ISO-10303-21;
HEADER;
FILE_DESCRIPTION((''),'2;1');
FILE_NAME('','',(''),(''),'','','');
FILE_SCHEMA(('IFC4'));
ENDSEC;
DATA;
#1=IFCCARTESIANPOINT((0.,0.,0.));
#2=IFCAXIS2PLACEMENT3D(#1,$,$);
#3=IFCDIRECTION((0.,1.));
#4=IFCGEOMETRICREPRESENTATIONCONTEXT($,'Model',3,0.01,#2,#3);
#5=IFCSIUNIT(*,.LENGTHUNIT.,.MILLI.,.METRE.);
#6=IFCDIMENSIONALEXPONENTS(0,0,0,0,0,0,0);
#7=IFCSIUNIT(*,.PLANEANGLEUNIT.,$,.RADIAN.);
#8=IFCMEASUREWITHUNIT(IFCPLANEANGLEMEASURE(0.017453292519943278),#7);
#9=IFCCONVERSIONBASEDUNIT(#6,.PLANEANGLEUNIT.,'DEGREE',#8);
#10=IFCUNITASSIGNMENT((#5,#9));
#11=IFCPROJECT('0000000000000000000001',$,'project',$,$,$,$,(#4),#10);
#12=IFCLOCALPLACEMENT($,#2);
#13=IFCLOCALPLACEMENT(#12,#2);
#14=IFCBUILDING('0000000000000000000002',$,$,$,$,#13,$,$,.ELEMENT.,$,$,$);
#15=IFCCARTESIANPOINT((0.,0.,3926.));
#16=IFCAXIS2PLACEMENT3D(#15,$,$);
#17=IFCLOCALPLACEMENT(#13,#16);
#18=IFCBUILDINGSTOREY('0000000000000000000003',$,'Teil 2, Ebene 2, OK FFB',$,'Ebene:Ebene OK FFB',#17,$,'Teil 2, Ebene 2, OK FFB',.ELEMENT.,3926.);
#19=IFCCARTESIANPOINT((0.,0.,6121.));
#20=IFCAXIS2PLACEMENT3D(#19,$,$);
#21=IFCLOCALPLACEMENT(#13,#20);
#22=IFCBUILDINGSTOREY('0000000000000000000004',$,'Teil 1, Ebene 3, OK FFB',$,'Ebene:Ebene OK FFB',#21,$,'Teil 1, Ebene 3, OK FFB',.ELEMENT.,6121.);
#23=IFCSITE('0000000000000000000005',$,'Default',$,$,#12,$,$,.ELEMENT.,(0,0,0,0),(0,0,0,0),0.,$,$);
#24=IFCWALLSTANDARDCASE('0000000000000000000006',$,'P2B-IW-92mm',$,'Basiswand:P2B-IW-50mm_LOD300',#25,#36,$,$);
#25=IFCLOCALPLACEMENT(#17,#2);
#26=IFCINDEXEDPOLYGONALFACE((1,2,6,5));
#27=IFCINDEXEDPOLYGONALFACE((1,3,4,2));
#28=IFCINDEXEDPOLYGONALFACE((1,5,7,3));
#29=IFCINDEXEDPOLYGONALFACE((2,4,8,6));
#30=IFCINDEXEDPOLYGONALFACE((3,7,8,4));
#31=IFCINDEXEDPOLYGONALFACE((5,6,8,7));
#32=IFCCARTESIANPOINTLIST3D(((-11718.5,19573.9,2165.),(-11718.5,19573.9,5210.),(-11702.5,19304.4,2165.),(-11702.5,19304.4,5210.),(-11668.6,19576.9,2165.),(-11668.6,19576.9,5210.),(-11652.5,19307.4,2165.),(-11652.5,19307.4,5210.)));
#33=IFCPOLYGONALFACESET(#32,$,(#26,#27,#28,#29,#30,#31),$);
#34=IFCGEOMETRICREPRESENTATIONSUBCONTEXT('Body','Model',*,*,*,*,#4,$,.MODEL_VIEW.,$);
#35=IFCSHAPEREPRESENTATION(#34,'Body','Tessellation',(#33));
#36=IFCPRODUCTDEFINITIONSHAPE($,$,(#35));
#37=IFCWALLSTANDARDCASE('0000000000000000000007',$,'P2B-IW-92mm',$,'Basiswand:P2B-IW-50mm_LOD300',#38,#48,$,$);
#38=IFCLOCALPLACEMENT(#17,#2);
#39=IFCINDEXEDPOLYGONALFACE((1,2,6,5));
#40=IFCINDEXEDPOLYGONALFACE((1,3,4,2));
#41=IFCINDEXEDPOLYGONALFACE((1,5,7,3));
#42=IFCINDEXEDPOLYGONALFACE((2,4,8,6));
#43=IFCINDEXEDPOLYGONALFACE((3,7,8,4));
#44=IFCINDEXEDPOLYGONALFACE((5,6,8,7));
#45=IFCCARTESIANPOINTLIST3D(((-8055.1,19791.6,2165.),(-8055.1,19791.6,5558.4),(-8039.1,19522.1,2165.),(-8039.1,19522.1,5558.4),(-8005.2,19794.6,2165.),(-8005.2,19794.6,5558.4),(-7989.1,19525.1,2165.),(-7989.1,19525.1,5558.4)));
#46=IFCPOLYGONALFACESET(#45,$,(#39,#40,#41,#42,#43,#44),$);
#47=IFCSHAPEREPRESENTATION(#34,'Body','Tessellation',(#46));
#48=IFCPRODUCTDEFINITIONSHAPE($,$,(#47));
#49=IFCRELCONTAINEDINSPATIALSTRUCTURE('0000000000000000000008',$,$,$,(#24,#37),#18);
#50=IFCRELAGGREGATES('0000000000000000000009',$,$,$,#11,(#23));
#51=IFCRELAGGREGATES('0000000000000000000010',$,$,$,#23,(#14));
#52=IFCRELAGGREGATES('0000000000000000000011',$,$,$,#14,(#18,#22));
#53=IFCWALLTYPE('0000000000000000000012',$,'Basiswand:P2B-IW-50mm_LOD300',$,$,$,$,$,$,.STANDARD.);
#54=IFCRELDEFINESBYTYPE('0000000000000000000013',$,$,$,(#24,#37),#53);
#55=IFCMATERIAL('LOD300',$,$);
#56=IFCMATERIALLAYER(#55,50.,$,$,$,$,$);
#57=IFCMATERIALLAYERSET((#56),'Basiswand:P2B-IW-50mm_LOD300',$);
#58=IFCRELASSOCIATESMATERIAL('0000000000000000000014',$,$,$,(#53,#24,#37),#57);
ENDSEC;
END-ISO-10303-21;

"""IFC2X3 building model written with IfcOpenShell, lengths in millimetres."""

from ifc_helpers import new_model, entity, si_unit, converted_unit, direction, frame, frame_2d, origin, place, context, subcontext, project, spatial, rectangle, extrude, material, layer, layer_set, layer_usage, type_object, element, save


model = new_model("IFC2X3")

# Units and contexts
model_context = context("Model", 3, precision=0.01, world=origin(), true_north=direction((0.0, 1.0)))
body_context = subcontext(model_context, "Body", "Model", "MODEL_VIEW")
ifc_project = project(units=[si_unit("LENGTHUNIT", "METRE", prefix="MILLI"), converted_unit("PLANEANGLEUNIT", "DEGREE", entity("IfcPlaneAngleMeasure", 0.017453292519943278), si_unit("PLANEANGLEUNIT", "RADIAN"), dimensions=[0, 0, 0, 0, 0, 0, 0])], contexts=[model_context])

# Site, building, storey
site_placement = place(None, origin())
site = spatial("IfcSite", under=ifc_project, at=site_placement, Name="Default", CompositionType="ELEMENT", RefLatitude=(0, 0, 0, 0), RefLongitude=(0, 0, 0, 0), RefElevation=0.0)
building_placement = place(site_placement, origin())
building = spatial("IfcBuilding", under=site, at=building_placement, CompositionType="ELEMENT")
storey_1_placement = place(building_placement, frame((0.0, 0.0, 3926.0)))
storey_1 = spatial("IfcBuildingStorey", under=building, at=storey_1_placement, Name="Teil 2, Ebene 2, OK FFB", ObjectType="Ebene:Ebene OK FFB", LongName="Teil 2, Ebene 2, OK FFB", CompositionType="ELEMENT", Elevation=3926.0)

# Shared definitions
storey_2_placement = place(building_placement, frame((0.0, 0.0, 6121.0)))
storey_2 = spatial("IfcBuildingStorey", under=building, at=storey_2_placement, Name="Teil 1, Ebene 3, OK FFB", ObjectType="Ebene:Ebene OK FFB", LongName="Teil 1, Ebene 3, OK FFB", CompositionType="ELEMENT", Elevation=6121.0)

# Shared definitions
ifc_material_1 = material(Name="LOD300")

# Shared definitions
ifc_layer_1 = layer(ifc_material_1, 50.0)
ifc_layer_set_1 = layer_set([ifc_layer_1], Name="Basiswand:P2B-IW-50mm_LOD300")
wall_type_1 = type_object("IfcWallType", Name="Basiswand:P2B-IW-50mm_LOD300", PredefinedType="STANDARD", material=ifc_layer_set_1)

# Walls
ifc_layer_usage_1 = layer_usage(ifc_layer_set_1, "AXIS2", "POSITIVE", -25.0)
wall_1_placement = place(storey_1_placement, frame((-11677.5, 19305.9, 2165.0), z_axis=(0.0, 0.0, 1.0), x_axis=(-0.059319, 0.998239, 0.0)))
element("IfcWallStandardCase", 1, at=wall_1_placement, inside=storey_1, type_object=wall_type_1, material=ifc_layer_usage_1, Name="P2B-IW-92mm", ObjectType="Basiswand:P2B-IW-50mm_LOD300", context=body_context, shape_type="SweptSolid", body=[
    extrude(rectangle(XDim=270.0, YDim=50.0, at=frame_2d((135.0, 0.0), x_axis=(-1.0, 0.0))), origin(), (0.0, 0.0, 1.0), 3045.0),
])
ifc_layer_usage_2 = layer_usage(ifc_layer_set_1, "AXIS2", "POSITIVE", -25.0)
wall_2_placement = place(storey_1_placement, frame((-8014.1, 19523.6, 2165.0), z_axis=(0.0, 0.0, 1.0), x_axis=(-0.059319, 0.998239, 0.0)))
element("IfcWallStandardCase", 2, at=wall_2_placement, inside=storey_1, type_object=wall_type_1, material=ifc_layer_usage_2, Name="P2B-IW-92mm", ObjectType="Basiswand:P2B-IW-50mm_LOD300", context=body_context, shape_type="SweptSolid", body=[
    extrude(rectangle(XDim=270.0, YDim=50.0, at=frame_2d((135.0, 0.0), x_axis=(-1.0, 0.0))), origin(), (0.0, 0.0, 1.0), 3393.4),
])

save(model, "model.ifc")
